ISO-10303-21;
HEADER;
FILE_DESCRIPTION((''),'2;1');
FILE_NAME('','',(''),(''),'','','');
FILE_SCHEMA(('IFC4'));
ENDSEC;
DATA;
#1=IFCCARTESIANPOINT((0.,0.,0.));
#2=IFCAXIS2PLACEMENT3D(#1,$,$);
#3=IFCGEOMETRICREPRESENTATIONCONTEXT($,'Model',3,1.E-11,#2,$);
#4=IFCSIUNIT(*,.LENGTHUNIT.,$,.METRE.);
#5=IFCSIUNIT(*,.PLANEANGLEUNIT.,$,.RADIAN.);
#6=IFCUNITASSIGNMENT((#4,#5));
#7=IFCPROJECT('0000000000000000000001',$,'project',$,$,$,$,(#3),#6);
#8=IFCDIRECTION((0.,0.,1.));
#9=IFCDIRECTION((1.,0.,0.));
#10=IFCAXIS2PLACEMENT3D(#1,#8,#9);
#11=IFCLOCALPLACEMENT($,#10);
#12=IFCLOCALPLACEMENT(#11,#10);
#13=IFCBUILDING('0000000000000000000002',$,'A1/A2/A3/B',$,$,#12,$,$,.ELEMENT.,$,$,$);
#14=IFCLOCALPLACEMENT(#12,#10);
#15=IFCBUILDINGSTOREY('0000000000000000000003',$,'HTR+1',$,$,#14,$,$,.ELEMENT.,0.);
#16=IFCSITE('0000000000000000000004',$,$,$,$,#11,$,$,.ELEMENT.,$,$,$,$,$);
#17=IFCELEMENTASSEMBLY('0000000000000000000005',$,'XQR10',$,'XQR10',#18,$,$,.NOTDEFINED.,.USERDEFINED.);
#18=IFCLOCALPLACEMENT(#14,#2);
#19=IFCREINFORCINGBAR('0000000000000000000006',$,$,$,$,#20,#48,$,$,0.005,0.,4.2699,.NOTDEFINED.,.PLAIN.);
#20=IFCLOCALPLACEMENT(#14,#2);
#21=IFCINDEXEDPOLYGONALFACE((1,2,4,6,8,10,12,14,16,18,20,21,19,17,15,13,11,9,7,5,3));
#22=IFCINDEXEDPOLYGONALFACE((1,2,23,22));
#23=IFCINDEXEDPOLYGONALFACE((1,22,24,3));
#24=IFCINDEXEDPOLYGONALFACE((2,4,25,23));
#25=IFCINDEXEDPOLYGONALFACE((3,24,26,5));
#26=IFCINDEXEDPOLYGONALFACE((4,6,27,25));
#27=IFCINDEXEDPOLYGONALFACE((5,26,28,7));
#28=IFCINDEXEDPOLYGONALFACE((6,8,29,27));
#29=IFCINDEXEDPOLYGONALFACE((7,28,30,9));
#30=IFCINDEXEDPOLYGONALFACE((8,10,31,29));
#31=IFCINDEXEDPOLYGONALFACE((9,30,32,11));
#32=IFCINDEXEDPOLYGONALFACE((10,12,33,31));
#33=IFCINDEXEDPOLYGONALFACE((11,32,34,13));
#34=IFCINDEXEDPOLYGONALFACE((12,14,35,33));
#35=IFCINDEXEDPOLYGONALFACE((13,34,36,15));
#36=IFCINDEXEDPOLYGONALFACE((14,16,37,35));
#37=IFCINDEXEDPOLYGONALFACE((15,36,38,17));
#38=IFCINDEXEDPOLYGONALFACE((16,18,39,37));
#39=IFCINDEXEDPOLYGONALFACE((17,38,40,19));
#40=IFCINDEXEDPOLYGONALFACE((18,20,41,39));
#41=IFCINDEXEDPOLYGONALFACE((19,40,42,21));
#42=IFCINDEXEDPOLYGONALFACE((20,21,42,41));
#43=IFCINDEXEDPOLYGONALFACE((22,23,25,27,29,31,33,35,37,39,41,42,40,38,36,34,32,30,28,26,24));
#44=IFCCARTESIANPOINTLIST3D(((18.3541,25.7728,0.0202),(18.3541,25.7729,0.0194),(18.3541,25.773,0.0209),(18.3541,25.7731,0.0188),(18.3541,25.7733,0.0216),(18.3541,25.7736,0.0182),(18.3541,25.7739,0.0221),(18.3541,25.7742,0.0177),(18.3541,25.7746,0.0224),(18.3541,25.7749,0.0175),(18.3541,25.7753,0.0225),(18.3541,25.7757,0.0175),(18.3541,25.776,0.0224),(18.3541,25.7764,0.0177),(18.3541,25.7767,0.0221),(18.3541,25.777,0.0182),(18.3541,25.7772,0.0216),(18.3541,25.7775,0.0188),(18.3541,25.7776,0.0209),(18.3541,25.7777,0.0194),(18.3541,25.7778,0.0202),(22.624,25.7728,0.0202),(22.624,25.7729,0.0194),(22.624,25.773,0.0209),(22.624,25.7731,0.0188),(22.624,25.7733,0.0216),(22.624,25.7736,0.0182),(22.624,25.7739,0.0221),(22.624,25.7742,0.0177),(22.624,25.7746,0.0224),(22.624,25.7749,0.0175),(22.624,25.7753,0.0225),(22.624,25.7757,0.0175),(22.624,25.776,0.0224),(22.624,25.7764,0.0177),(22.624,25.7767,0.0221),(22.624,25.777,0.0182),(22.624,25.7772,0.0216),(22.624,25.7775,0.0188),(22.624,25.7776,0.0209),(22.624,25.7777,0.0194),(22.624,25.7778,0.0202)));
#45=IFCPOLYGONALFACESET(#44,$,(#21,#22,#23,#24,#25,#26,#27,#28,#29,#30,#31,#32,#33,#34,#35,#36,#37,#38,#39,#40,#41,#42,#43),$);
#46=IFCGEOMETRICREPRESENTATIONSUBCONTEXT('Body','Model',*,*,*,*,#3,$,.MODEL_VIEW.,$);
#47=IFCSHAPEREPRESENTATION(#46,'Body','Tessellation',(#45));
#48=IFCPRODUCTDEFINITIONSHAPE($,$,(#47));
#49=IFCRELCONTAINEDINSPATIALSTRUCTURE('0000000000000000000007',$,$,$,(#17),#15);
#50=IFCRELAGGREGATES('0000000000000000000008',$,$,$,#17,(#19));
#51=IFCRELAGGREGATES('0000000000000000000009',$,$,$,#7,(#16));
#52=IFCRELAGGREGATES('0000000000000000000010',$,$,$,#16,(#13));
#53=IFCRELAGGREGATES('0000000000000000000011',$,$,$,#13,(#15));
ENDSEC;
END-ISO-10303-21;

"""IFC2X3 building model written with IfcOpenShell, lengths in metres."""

from ifc_helpers import new_model, entity, si_unit, origin, origin_with_axes, place, context, subcontext, project, spatial, shape, element, aggregate, save


model = new_model("IFC2X3")

# Units and contexts
model_context = context("Model", 3, precision=1e-11, world=origin())
body_context = subcontext(model_context, "Body", "Model", "MODEL_VIEW")
ifc_project = project(units=[si_unit("LENGTHUNIT", "METRE"), si_unit("PLANEANGLEUNIT", "RADIAN")], contexts=[model_context])

# Site, building, storey
site_placement = place(None, origin_with_axes())
site = spatial("IfcSite", under=ifc_project, at=site_placement, CompositionType="ELEMENT")
building_placement = place(site_placement, origin_with_axes())
building = spatial("IfcBuilding", under=site, at=building_placement, Name="A1/A2/A3/B", CompositionType="ELEMENT")
storey_placement = place(building_placement, origin_with_axes())
storey = spatial("IfcBuildingStorey", under=building, at=storey_placement, Name="HTR+1", CompositionType="ELEMENT", Elevation=0.0)

# Element assembly, reinforcing bar
assembly_1_placement = place(storey_placement, origin_with_axes())
assembly_1 = element("IfcElementAssembly", 1, at=assembly_1_placement, inside=storey, Name="XQR10", ObjectType="XQR10", AssemblyPlace="NOTDEFINED", PredefinedType="USERDEFINED")
reinforcing_bar_1_placement = place(assembly_1_placement, origin_with_axes())
reinforcing_bar_1 = element("IfcReinforcingBar", 2, at=reinforcing_bar_1_placement, BarLength=4.2699, BarRole="NOTDEFINED", BarSurface="PLAIN", CrossSectionArea=0.0, NominalDiameter=0.005, shapes=[
    shape(body_context, "Body", "AdvancedSweptSolid", [entity("IfcSweptDiskSolid", entity("IfcPolyline", [entity("IfcCartesianPoint", [18.3541, 25.7753, 0.02]), entity("IfcCartesianPoint", [22.624, 25.7753, 0.02])]), 0.0025, None, 0.0, 4.2699)]),
    shape(body_context, "Body", "AdvancedSweptSolid", [entity("IfcSweptDiskSolid", entity("IfcPolyline", [entity("IfcCartesianPoint", [18.3541, 25.7753, 0.02]), entity("IfcCartesianPoint", [22.624, 25.7753, 0.02])]), 0.0025, None, 0.0, 4.2699)]),
])
aggregate(assembly_1, [reinforcing_bar_1])

save(model, "model.ifc")
